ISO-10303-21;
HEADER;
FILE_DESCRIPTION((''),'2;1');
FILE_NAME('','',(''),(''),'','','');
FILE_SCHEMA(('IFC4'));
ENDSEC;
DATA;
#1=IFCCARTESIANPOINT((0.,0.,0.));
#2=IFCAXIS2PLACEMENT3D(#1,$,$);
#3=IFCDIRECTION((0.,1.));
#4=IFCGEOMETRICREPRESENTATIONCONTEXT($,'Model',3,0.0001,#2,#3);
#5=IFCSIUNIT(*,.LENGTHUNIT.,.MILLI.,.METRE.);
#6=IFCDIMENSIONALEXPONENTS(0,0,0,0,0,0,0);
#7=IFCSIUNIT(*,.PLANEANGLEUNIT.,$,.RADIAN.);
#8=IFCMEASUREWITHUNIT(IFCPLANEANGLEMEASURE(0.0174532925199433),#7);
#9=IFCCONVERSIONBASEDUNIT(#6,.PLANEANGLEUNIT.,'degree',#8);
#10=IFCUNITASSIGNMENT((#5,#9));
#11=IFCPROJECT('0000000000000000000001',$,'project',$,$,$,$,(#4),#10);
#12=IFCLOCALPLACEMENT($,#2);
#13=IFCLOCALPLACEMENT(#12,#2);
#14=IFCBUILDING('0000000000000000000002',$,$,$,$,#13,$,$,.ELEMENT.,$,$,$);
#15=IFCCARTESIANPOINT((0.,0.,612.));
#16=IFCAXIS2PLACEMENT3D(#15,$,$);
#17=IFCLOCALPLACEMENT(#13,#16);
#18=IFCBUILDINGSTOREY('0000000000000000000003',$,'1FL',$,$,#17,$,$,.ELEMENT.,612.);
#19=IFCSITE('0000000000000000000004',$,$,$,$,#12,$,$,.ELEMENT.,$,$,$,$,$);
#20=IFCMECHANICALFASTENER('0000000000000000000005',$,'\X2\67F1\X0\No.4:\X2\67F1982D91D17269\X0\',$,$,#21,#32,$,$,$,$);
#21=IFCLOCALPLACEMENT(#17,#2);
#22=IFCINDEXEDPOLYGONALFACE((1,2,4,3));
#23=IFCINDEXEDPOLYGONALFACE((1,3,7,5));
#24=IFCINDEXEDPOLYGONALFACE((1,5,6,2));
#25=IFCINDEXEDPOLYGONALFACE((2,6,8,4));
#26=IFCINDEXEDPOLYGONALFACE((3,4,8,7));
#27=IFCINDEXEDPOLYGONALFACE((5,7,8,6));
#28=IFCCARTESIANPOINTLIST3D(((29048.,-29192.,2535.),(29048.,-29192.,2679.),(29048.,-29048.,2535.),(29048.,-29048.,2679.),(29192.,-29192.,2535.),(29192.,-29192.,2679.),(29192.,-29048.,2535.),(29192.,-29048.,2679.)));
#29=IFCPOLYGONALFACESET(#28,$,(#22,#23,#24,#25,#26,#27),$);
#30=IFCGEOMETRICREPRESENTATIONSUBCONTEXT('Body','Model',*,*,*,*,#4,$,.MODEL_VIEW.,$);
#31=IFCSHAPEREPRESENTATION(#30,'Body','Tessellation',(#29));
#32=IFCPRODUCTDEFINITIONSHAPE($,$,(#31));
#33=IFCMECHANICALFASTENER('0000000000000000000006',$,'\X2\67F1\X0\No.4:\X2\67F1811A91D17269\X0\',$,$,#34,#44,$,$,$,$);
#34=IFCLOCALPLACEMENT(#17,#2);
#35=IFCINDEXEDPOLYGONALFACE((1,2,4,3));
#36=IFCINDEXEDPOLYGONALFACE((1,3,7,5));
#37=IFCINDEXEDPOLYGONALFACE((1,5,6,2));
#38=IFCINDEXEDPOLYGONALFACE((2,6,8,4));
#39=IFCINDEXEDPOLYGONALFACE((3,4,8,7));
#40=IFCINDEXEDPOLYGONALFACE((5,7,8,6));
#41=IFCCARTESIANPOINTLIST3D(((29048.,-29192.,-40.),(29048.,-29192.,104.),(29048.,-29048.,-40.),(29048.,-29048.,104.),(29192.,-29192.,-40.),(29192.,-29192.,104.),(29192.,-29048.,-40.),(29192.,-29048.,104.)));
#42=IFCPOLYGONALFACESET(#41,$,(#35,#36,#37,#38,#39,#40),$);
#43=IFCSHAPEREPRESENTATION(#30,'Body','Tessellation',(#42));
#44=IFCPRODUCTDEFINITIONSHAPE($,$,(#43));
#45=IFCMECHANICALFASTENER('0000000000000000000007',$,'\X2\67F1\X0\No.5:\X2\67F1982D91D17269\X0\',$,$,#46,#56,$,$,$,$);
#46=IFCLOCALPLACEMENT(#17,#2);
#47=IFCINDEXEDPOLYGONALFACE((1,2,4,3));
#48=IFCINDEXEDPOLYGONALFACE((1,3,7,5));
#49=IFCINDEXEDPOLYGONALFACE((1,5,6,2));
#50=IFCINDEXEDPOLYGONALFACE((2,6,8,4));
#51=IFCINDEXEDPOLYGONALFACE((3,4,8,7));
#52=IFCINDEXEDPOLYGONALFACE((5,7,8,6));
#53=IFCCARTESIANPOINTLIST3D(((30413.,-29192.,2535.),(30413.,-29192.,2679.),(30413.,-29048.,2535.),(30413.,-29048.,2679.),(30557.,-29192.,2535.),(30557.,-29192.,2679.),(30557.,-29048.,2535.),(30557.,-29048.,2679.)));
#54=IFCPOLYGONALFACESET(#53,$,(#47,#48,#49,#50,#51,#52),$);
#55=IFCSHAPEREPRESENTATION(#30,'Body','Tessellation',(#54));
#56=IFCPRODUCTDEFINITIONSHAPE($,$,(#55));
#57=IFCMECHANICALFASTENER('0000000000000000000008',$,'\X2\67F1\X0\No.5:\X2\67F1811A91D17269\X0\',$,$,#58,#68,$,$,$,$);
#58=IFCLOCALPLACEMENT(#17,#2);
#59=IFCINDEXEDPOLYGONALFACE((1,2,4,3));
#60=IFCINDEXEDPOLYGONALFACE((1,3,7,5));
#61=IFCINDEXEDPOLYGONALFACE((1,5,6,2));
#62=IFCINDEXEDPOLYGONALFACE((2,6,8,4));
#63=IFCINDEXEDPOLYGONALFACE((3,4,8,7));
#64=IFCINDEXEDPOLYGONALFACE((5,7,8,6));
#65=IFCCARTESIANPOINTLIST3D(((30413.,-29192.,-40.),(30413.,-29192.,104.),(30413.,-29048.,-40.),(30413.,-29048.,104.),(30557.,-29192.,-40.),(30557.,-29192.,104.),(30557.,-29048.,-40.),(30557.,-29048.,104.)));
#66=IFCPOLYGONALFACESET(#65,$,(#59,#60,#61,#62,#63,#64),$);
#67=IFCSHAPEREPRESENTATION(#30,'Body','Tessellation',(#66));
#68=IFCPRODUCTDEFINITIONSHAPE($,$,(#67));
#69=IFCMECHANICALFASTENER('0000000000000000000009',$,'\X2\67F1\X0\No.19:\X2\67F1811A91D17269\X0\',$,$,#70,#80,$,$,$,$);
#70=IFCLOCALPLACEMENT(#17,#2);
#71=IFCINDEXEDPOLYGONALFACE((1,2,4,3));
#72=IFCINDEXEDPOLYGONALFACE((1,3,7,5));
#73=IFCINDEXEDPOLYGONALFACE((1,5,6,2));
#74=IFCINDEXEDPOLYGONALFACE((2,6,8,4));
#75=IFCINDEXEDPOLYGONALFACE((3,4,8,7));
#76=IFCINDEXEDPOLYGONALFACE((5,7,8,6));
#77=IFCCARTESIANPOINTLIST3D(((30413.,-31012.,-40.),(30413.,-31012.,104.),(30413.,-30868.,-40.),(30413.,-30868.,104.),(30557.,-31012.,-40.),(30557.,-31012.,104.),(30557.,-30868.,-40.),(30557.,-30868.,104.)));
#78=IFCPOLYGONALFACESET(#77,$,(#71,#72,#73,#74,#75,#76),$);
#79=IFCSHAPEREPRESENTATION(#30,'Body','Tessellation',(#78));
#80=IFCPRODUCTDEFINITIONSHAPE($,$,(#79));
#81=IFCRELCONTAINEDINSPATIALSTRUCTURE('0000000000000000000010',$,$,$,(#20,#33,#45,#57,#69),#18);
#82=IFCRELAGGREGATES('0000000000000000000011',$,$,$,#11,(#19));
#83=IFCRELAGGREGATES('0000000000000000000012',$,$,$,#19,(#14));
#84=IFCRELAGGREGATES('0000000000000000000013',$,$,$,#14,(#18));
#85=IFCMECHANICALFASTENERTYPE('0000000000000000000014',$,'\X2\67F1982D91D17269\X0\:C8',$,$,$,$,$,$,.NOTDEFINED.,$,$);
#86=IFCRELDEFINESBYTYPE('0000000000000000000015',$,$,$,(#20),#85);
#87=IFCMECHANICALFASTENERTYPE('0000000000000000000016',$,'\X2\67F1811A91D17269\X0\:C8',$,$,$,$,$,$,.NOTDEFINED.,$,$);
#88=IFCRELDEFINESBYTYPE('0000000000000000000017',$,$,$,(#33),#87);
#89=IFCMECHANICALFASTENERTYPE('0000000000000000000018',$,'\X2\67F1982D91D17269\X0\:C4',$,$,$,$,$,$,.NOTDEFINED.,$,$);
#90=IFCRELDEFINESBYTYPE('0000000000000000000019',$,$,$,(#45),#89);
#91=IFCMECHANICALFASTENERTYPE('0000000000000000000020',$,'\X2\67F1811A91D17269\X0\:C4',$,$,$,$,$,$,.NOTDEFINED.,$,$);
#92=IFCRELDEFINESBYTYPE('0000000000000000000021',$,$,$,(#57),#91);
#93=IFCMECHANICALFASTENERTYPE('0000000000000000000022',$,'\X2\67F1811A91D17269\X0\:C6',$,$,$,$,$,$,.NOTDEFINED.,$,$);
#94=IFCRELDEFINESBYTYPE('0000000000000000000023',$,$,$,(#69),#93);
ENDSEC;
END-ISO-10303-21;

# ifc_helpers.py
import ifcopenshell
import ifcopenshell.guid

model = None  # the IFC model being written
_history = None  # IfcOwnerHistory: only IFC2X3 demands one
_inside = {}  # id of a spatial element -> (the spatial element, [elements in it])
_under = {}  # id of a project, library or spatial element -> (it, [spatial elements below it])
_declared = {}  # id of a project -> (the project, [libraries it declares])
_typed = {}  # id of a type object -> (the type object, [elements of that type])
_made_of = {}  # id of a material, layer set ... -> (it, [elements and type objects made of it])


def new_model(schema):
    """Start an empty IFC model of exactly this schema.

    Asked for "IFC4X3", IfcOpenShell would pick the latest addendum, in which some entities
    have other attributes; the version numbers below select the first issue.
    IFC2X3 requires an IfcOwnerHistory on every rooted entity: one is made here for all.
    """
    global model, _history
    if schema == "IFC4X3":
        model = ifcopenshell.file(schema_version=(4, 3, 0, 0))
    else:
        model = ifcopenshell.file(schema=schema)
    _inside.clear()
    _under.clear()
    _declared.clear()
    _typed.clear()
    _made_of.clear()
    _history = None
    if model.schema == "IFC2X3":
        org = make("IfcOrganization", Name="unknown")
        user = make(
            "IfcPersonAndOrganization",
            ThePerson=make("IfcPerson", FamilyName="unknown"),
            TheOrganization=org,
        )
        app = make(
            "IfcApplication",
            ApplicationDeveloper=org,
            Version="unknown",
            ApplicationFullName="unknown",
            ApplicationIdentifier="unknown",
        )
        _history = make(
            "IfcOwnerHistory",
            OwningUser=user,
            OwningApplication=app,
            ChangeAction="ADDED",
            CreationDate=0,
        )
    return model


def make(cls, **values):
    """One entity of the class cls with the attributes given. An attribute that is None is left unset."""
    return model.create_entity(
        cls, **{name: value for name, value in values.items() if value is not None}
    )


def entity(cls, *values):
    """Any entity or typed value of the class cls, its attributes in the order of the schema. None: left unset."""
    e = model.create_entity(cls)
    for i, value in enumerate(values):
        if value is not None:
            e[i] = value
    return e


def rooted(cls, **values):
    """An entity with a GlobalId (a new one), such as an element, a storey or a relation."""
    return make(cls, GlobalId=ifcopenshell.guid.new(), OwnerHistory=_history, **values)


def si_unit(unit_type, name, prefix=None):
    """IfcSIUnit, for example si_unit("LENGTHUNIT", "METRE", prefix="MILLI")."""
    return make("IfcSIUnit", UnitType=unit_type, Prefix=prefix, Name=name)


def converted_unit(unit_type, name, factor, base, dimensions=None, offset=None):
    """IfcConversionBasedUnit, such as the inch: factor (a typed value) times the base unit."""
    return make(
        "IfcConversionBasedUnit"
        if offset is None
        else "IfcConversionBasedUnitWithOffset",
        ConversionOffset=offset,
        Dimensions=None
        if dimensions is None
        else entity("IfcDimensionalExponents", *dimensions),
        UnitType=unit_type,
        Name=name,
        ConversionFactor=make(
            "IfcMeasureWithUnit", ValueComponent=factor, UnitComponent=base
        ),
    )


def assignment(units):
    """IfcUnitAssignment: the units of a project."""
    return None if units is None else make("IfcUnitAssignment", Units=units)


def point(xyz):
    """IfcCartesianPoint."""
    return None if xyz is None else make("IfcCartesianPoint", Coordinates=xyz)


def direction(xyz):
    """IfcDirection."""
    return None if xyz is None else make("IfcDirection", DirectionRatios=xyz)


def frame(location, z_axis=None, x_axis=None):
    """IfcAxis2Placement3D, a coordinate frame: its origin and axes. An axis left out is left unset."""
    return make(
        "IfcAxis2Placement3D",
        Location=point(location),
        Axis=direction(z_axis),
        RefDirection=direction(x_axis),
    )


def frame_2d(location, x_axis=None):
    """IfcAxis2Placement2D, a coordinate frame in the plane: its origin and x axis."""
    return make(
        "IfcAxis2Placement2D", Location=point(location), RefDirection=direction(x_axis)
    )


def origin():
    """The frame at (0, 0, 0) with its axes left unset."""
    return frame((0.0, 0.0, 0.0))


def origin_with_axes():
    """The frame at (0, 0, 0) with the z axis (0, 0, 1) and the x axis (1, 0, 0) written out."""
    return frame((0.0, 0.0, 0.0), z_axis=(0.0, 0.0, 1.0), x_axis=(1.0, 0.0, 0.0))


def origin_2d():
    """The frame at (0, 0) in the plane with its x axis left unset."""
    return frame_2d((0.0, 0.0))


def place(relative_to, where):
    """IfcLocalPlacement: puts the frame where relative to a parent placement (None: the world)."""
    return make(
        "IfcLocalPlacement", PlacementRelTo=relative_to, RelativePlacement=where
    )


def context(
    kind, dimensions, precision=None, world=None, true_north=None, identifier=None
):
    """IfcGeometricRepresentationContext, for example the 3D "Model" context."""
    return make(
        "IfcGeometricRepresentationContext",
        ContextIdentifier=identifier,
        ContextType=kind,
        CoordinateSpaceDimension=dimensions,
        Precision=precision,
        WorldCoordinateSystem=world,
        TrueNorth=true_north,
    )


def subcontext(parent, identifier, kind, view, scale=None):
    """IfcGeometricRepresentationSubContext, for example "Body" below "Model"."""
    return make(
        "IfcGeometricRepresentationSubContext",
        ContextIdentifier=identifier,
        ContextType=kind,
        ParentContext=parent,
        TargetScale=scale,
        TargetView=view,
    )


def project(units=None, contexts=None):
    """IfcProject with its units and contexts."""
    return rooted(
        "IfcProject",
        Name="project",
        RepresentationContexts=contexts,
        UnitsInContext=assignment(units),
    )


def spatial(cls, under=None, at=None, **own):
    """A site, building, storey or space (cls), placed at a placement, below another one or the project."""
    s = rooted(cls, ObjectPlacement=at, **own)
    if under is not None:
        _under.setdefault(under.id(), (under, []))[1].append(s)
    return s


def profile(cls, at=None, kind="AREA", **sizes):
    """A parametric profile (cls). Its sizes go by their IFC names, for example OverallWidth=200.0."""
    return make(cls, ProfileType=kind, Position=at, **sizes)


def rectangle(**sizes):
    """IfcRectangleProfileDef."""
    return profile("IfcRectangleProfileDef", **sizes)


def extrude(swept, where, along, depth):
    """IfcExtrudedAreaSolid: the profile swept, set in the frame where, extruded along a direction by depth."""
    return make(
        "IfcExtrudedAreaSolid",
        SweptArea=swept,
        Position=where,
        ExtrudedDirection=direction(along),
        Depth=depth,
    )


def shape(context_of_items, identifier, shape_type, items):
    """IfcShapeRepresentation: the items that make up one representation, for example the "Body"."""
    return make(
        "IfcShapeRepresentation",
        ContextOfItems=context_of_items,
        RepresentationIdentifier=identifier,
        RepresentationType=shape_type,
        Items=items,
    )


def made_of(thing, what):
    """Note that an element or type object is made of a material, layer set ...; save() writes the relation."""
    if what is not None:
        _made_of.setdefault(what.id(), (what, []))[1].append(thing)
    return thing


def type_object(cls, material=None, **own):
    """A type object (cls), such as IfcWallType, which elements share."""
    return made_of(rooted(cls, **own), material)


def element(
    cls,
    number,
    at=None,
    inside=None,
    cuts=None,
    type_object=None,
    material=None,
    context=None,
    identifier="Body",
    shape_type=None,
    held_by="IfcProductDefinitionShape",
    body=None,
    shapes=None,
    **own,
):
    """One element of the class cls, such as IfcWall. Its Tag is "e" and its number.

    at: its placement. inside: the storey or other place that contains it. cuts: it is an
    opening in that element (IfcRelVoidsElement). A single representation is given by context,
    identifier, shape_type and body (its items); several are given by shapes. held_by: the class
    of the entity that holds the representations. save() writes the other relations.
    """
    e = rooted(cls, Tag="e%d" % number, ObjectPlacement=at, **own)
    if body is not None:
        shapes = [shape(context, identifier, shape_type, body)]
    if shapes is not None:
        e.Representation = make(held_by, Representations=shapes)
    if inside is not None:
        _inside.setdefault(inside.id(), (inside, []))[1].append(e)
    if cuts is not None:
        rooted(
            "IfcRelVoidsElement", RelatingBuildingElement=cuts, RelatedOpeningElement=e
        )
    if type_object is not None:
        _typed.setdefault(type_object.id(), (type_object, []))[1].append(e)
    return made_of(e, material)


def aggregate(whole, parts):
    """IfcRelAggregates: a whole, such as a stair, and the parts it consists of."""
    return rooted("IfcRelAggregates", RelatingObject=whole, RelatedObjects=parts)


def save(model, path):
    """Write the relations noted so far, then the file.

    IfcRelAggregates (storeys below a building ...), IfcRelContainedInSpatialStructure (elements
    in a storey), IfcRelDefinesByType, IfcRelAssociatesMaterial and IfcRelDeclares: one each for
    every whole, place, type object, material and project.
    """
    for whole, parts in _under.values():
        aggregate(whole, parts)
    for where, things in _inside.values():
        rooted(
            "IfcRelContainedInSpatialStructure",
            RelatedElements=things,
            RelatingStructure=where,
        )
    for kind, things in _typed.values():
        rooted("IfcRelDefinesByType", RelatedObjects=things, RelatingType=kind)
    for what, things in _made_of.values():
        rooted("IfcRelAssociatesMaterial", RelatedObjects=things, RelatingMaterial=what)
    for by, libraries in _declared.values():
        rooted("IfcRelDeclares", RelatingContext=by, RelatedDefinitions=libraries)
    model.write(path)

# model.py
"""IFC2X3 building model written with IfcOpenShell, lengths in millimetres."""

from ifc_helpers import new_model, entity, si_unit, converted_unit, direction, frame, origin, origin_with_axes, origin_2d, place, context, subcontext, project, spatial, rectangle, extrude, type_object, element, save


model = new_model("IFC2X3")

# Units and contexts
model_context = context("Model", 3, precision=0.0001, world=origin(), true_north=direction((0.0, 1.0)))
body_context = subcontext(model_context, "Body", "Model", "MODEL_VIEW")
ifc_project = project(units=[si_unit("LENGTHUNIT", "METRE", prefix="MILLI"), converted_unit("PLANEANGLEUNIT", "degree", entity("IfcPlaneAngleMeasure", 0.0174532925199433), si_unit("PLANEANGLEUNIT", "RADIAN"), dimensions=[0, 0, 0, 0, 0, 0, 0])], contexts=[model_context])

# Site, building, storey
site_placement = place(None, origin())
site = spatial("IfcSite", under=ifc_project, at=site_placement, CompositionType="ELEMENT")
building_placement = place(site_placement, origin())
building = spatial("IfcBuilding", under=site, at=building_placement, CompositionType="ELEMENT")
storey_placement = place(building_placement, frame((0.0, 0.0, 612.0)))
storey = spatial("IfcBuildingStorey", under=building, at=storey_placement, Name="1FL", CompositionType="ELEMENT", Elevation=612.0)

# Mechanical fasteners
mechanical_fastener_type_1 = type_object("IfcMechanicalFastenerType", Name="柱頭金物:C8")
mechanical_fastener_1_placement = place(storey_placement, frame((29120.0, -29120.0, 2535.0)))
element("IfcMechanicalFastener", 1, at=mechanical_fastener_1_placement, inside=storey, type_object=mechanical_fastener_type_1, Name="柱No.4:柱頭金物", context=body_context, shape_type="SweptSolid", body=[
    extrude(rectangle(XDim=144.0, YDim=144.0, at=origin_2d()), origin_with_axes(), (0.0, 0.0, 1.0), 144.0),
])
mechanical_fastener_type_2 = type_object("IfcMechanicalFastenerType", Name="柱脚金物:C8")
mechanical_fastener_2_placement = place(storey_placement, frame((29120.0, -29120.0, -40.0)))
element("IfcMechanicalFastener", 2, at=mechanical_fastener_2_placement, inside=storey, type_object=mechanical_fastener_type_2, Name="柱No.4:柱脚金物", context=body_context, shape_type="SweptSolid", body=[
    extrude(rectangle(XDim=144.0, YDim=144.0, at=origin_2d()), origin_with_axes(), (0.0, 0.0, 1.0), 144.0),
])
mechanical_fastener_type_3 = type_object("IfcMechanicalFastenerType", Name="柱頭金物:C4")
mechanical_fastener_3_placement = place(storey_placement, frame((30485.0, -29120.0, 2535.0)))
element("IfcMechanicalFastener", 3, at=mechanical_fastener_3_placement, inside=storey, type_object=mechanical_fastener_type_3, Name="柱No.5:柱頭金物", context=body_context, shape_type="SweptSolid", body=[
    extrude(rectangle(XDim=144.0, YDim=144.0, at=origin_2d()), origin_with_axes(), (0.0, 0.0, 1.0), 144.0),
])
mechanical_fastener_type_4 = type_object("IfcMechanicalFastenerType", Name="柱脚金物:C4")
mechanical_fastener_4_placement = place(storey_placement, frame((30485.0, -29120.0, -40.0)))
element("IfcMechanicalFastener", 4, at=mechanical_fastener_4_placement, inside=storey, type_object=mechanical_fastener_type_4, Name="柱No.5:柱脚金物", context=body_context, shape_type="SweptSolid", body=[
    extrude(rectangle(XDim=144.0, YDim=144.0, at=origin_2d()), origin_with_axes(), (0.0, 0.0, 1.0), 144.0),
])
mechanical_fastener_type_5 = type_object("IfcMechanicalFastenerType", Name="柱脚金物:C6")
mechanical_fastener_5_placement = place(storey_placement, frame((30485.0, -30940.0, -40.0)))
element("IfcMechanicalFastener", 5, at=mechanical_fastener_5_placement, inside=storey, type_object=mechanical_fastener_type_5, Name="柱No.19:柱脚金物", context=body_context, shape_type="SweptSolid", body=[
    extrude(rectangle(XDim=144.0, YDim=144.0, at=origin_2d()), origin_with_axes(), (0.0, 0.0, 1.0), 144.0),
])

save(model, "model.ifc")
